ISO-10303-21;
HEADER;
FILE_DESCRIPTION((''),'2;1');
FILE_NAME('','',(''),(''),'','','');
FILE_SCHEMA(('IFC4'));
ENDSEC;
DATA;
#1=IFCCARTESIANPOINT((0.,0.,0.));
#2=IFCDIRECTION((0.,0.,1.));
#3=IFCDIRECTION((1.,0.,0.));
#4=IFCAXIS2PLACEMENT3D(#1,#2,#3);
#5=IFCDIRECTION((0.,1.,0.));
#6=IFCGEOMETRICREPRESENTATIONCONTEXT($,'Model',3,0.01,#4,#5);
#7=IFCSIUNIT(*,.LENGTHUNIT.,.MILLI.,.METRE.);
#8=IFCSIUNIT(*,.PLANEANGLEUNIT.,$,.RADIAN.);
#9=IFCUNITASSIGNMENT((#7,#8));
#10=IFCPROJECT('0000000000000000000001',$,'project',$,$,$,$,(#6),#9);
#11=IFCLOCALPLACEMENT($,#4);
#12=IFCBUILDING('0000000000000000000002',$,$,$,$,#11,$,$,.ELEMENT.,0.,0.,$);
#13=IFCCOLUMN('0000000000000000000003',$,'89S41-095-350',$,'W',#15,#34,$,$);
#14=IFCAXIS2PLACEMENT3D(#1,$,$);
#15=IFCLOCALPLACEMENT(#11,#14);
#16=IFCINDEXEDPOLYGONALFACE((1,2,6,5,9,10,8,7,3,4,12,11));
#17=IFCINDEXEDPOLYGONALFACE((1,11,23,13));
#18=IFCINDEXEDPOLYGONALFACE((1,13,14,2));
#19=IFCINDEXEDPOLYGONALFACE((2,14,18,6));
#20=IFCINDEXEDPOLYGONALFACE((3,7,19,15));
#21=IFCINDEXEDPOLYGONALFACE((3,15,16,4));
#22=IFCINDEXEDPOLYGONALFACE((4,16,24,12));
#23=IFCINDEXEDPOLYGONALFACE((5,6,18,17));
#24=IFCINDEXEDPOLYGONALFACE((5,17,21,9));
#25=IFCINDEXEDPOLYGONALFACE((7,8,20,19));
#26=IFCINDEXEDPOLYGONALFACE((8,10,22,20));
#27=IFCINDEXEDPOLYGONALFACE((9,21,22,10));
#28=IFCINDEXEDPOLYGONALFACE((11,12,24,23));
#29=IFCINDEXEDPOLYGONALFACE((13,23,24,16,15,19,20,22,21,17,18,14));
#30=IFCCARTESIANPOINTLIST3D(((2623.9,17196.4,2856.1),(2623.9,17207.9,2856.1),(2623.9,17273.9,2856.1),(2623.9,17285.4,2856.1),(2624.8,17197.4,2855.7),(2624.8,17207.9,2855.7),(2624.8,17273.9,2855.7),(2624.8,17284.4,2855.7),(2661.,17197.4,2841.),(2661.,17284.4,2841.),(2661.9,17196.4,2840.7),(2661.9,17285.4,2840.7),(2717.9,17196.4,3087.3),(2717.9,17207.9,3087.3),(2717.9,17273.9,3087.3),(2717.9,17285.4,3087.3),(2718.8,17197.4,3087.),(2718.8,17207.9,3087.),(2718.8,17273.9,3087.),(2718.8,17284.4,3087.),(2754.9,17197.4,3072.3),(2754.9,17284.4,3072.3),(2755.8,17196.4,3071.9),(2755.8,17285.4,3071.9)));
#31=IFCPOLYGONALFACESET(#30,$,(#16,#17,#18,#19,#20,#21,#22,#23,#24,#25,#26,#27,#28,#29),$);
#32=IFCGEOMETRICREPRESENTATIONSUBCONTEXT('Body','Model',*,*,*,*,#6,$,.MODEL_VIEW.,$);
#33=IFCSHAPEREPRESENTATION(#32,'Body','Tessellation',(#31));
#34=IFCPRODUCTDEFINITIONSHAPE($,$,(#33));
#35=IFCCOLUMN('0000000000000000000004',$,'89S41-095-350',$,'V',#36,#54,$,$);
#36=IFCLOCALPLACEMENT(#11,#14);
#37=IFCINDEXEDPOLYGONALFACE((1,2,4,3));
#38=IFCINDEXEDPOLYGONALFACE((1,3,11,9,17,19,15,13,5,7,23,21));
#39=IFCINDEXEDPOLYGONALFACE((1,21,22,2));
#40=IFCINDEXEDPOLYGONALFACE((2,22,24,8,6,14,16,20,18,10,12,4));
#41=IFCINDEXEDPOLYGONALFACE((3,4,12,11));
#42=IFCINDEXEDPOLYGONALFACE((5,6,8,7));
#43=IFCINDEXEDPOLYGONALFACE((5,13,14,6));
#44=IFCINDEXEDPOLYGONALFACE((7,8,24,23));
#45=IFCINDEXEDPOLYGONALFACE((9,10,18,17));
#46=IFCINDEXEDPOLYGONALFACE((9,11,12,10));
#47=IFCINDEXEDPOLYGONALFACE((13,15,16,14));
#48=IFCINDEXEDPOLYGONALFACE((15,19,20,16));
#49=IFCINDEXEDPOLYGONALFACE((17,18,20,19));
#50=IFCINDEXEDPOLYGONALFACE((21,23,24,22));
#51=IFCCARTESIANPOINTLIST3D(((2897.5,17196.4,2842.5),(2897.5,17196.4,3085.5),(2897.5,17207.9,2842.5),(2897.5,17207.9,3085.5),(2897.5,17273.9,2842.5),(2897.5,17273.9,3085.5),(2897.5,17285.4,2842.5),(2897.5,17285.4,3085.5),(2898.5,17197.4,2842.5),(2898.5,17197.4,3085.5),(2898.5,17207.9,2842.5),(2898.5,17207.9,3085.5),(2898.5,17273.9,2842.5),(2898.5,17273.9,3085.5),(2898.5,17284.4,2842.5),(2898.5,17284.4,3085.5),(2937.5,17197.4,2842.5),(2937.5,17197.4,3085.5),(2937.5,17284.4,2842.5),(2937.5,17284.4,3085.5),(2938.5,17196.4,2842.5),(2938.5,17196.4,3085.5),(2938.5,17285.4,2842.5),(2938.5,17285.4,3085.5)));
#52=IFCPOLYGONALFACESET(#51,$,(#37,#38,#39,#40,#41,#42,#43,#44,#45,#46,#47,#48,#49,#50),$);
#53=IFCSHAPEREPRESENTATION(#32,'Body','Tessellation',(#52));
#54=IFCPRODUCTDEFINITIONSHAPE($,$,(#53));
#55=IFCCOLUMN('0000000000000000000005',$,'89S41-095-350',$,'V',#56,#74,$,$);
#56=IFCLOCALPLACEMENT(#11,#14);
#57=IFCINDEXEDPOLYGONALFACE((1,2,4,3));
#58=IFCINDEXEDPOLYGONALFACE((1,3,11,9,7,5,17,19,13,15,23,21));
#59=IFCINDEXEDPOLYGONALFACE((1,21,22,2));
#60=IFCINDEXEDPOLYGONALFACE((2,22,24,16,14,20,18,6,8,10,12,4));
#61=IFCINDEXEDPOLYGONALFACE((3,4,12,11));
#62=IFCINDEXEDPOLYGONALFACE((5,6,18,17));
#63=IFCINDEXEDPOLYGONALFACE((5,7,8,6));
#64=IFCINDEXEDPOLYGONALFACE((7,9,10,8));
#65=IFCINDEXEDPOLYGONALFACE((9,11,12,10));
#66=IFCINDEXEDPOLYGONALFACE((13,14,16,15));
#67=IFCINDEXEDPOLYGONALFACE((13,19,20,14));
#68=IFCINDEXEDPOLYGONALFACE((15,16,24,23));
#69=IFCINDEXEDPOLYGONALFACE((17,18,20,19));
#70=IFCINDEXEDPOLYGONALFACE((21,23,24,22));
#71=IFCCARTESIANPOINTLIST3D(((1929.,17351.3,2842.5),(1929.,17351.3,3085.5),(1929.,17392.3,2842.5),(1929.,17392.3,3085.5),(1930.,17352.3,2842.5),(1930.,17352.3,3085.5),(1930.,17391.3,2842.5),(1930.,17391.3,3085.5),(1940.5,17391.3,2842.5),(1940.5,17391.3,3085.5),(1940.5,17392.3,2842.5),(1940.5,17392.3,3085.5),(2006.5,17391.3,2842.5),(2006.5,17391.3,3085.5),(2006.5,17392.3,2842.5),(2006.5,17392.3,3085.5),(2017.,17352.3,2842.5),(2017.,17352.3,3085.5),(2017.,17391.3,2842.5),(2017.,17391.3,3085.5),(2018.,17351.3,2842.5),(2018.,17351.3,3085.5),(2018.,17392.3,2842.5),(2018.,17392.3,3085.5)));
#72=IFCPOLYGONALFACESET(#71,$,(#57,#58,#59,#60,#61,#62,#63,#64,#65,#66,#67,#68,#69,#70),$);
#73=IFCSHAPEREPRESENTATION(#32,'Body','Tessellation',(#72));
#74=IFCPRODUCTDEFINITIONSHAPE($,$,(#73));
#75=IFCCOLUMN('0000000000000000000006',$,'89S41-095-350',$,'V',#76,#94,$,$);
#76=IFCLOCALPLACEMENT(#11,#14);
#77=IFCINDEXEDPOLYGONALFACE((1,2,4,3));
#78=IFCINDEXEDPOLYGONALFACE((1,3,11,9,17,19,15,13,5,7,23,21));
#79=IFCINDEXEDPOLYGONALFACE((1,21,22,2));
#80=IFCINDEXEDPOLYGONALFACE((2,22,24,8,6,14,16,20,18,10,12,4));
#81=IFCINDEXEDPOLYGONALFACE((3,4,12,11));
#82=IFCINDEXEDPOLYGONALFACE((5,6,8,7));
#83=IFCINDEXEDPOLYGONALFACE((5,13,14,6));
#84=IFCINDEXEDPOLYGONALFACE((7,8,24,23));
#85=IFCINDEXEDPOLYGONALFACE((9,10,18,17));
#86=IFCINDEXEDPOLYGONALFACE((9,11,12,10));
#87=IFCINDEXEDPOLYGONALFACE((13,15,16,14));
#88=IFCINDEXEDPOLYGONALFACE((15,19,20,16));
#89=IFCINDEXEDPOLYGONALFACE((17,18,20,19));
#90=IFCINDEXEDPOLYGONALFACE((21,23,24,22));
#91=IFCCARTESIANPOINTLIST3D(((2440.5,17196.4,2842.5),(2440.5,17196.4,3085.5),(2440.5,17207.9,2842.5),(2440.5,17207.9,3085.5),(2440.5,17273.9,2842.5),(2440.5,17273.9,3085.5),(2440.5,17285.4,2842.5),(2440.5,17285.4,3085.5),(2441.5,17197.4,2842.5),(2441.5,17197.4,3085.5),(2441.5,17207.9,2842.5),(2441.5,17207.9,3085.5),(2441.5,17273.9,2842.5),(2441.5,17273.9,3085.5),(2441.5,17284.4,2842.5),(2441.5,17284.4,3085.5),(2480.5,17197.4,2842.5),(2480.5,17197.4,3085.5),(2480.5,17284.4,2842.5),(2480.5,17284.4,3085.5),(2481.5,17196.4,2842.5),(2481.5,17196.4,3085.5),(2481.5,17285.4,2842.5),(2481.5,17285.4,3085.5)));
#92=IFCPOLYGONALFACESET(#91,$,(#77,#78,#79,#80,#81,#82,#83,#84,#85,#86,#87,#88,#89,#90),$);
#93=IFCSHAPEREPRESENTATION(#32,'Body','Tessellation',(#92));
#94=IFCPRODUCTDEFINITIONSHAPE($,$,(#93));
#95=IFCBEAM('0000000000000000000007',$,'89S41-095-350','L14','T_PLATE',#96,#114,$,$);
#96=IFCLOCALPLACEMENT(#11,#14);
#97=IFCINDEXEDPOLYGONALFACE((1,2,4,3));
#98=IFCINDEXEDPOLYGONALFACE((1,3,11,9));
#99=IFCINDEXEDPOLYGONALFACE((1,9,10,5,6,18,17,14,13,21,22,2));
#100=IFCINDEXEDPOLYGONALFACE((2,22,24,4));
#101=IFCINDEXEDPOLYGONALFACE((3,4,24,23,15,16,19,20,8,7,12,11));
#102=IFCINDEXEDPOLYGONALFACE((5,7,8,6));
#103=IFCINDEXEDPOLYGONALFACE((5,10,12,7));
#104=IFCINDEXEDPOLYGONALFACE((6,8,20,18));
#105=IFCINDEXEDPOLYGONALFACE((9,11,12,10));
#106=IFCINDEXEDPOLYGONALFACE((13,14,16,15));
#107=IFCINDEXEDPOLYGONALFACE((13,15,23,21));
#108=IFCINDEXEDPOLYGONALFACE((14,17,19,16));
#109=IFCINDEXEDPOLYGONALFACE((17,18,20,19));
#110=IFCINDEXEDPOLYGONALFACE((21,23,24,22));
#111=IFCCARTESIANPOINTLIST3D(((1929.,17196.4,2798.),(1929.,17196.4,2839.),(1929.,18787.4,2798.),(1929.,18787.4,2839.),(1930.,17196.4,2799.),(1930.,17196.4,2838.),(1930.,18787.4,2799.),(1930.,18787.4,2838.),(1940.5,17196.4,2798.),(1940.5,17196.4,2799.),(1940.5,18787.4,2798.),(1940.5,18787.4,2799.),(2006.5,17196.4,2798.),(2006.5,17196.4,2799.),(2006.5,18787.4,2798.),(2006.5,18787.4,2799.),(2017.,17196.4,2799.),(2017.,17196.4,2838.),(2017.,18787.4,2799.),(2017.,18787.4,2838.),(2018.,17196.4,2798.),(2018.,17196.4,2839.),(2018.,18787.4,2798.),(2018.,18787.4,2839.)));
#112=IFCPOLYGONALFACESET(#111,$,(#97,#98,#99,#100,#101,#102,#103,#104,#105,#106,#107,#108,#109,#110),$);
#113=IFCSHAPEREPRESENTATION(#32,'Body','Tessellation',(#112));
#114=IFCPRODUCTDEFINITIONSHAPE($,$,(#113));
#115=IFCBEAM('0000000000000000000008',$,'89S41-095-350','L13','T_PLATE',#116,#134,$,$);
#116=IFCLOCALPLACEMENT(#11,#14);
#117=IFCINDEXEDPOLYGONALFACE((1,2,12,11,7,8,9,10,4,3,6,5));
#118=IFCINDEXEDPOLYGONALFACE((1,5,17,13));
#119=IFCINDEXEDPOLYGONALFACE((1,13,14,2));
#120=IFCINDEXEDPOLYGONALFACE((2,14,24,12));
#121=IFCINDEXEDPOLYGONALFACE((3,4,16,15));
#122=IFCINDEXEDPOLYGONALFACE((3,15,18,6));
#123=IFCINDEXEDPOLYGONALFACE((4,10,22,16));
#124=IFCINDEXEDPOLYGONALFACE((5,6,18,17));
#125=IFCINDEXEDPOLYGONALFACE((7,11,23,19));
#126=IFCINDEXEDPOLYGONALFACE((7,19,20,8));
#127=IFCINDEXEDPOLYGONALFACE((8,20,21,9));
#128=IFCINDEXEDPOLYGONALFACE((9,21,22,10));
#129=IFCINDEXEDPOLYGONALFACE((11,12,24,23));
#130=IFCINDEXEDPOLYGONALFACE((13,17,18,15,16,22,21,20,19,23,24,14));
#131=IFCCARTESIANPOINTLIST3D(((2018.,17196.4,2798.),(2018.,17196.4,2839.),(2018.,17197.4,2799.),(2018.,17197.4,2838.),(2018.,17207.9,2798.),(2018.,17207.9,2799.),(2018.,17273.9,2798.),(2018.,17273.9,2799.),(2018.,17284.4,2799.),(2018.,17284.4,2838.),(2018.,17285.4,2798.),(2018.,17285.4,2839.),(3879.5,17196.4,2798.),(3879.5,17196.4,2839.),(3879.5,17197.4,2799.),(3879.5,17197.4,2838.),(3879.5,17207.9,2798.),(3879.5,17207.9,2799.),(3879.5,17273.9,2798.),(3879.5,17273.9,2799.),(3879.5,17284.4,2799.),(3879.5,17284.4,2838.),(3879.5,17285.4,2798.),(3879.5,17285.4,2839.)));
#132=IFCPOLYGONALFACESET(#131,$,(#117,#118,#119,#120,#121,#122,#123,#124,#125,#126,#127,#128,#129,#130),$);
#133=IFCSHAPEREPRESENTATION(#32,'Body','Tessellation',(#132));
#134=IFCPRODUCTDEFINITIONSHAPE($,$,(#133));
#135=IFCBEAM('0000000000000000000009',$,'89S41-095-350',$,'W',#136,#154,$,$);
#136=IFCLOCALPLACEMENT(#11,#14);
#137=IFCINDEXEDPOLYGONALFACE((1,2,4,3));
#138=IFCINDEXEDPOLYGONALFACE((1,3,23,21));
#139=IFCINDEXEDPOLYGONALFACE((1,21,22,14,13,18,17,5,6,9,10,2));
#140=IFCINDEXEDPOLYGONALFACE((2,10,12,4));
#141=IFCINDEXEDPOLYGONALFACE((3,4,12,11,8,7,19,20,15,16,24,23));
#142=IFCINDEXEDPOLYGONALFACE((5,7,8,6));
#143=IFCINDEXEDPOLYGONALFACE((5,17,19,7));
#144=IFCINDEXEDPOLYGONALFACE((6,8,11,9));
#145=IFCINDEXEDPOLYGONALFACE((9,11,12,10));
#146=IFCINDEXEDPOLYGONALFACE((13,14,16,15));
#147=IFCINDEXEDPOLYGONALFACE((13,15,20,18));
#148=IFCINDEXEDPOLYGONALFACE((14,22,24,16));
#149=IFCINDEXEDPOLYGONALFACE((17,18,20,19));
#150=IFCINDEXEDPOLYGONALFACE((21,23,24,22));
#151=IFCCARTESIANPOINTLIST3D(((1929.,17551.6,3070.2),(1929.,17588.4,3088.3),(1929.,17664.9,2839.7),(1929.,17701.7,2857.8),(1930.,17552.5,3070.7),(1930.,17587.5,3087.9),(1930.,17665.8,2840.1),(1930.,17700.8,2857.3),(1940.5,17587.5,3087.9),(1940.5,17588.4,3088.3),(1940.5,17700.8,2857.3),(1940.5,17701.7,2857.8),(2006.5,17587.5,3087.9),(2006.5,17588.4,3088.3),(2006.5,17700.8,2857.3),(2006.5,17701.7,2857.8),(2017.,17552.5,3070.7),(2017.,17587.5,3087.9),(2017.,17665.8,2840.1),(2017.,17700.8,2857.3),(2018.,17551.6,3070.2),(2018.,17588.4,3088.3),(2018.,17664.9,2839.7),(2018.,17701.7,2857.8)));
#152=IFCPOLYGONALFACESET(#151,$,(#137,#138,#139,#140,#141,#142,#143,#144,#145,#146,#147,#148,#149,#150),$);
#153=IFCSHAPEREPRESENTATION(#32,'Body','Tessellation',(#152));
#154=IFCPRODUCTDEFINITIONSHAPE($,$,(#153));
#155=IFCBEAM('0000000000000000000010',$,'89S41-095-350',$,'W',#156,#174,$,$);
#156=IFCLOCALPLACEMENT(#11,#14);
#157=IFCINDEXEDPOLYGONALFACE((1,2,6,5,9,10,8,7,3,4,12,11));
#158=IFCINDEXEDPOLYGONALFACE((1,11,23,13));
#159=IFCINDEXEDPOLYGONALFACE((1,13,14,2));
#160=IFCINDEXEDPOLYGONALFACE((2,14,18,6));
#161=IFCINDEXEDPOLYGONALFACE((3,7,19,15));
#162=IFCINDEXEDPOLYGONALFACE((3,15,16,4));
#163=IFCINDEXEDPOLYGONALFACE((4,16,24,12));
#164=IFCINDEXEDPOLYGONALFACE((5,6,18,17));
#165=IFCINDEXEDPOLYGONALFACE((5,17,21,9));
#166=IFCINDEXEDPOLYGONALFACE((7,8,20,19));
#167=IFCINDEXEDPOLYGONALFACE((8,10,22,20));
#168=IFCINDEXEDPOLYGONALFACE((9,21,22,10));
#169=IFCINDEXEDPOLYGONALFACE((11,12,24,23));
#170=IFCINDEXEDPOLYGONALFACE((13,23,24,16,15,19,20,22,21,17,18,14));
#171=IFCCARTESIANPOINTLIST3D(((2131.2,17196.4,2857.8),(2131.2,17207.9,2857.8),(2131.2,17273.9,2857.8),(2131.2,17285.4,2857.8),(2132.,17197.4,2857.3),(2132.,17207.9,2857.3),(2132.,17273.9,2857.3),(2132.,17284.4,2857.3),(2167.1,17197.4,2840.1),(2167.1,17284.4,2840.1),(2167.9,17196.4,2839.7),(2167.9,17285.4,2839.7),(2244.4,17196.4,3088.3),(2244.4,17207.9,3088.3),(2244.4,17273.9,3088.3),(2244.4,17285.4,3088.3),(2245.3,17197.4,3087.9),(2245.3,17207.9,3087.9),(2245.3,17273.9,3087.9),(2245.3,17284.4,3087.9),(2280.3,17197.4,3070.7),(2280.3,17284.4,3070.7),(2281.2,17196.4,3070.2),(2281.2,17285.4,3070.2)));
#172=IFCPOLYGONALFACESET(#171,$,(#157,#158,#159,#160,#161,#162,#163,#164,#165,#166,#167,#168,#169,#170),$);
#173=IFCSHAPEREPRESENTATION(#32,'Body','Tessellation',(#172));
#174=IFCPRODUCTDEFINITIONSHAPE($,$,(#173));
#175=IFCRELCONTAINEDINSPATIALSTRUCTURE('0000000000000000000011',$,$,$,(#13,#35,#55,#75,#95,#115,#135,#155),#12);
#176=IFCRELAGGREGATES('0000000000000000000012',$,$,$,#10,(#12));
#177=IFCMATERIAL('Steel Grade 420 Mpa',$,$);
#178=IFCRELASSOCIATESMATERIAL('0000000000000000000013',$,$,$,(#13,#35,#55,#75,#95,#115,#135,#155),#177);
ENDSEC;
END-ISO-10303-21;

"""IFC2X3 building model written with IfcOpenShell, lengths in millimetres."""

from ifc_helpers import new_model, si_unit, direction, frame, origin, origin_with_axes, origin_2d_with_axis, place, context, subcontext, project, spatial, c_section, extrude, source, transform, mapped, material, element, save


model = new_model("IFC2X3")

# Units and contexts
model_context = context("Model", 3, precision=0.01, world=origin_with_axes(), true_north=direction((0.0, 1.0, 0.0)))
body_context = subcontext(model_context, "Body", "Model", "MODEL_VIEW")
ifc_project = project(units=[si_unit("LENGTHUNIT", "METRE", prefix="MILLI"), si_unit("PLANEANGLEUNIT", "RADIAN")], contexts=[model_context])

# Building
building_placement = place(None, origin_with_axes())
building = spatial("IfcBuilding", under=ifc_project, at=building_placement, CompositionType="ELEMENT", ElevationOfRefHeight=0.0, ElevationOfTerrain=0.0)

# Columns
ifc_material = material(Name="Steel Grade 420 Mpa")
shared_shape_1 = source(origin(), body_context, "Body", "SweptSolid", [
    extrude(c_section(Depth=89.0, Width=41.0, WallThickness=1.0, Girth=11.5, at=origin_2d_with_axis()), origin_with_axes(), (0.0, 0.0, 1.0), 249.6),
])
column_1_placement = place(None, frame((2642.9, 17240.9, 2848.4), z_axis=(0.376416, 0.0, 0.926451), x_axis=(-0.926451, 0.0, 0.376416)))
element("IfcColumn", 1, at=column_1_placement, inside=building, material=ifc_material, Name="89S41-095-350", ObjectType="W", context=body_context, shape_type="MappedRepresentation", body=[
    mapped(shared_shape_1, transform((0.0, 0.0, 0.0), scale=1.0)),
])
shared_shape_2 = source(origin(), body_context, "Body", "SweptSolid", [
    extrude(c_section(Depth=89.0, Width=41.0, WallThickness=1.0, Girth=11.5, at=origin_2d_with_axis()), origin_with_axes(), (0.0, 0.0, 1.0), 243.0),
])
column_2_placement = place(None, frame((2918.0, 17240.9, 2842.5), z_axis=(0.0, 0.0, 1.0), x_axis=(-1.0, 0.0, 0.0)))
element("IfcColumn", 2, at=column_2_placement, inside=building, material=ifc_material, Name="89S41-095-350", ObjectType="V", context=body_context, shape_type="MappedRepresentation", body=[
    mapped(shared_shape_2, transform((0.0, 0.0, 0.0), scale=1.0)),
])
shared_shape_3 = source(origin(), body_context, "Body", "SweptSolid", [
    extrude(c_section(Depth=89.0, Width=41.0, WallThickness=1.0, Girth=11.5, at=origin_2d_with_axis()), origin_with_axes(), (0.0, 0.0, 1.0), 243.0),
])
column_3_placement = place(None, frame((1973.5, 17371.8, 2842.5), z_axis=(0.0, 0.0, 1.0), x_axis=(0.0, 1.0, 0.0)))
element("IfcColumn", 3, at=column_3_placement, inside=building, material=ifc_material, Name="89S41-095-350", ObjectType="V", context=body_context, shape_type="MappedRepresentation", body=[
    mapped(shared_shape_3, transform((0.0, 0.0, 0.0), scale=1.0)),
])
shared_shape_4 = source(origin(), body_context, "Body", "SweptSolid", [
    extrude(c_section(Depth=89.0, Width=41.0, WallThickness=1.0, Girth=11.5, at=origin_2d_with_axis()), origin_with_axes(), (0.0, 0.0, 1.0), 243.0),
])
column_4_placement = place(None, frame((2461.0, 17240.9, 2842.5), z_axis=(0.0, 0.0, 1.0), x_axis=(-1.0, 0.0, 0.0)))
element("IfcColumn", 4, at=column_4_placement, inside=building, material=ifc_material, Name="89S41-095-350", ObjectType="V", context=body_context, shape_type="MappedRepresentation", body=[
    mapped(shared_shape_4, transform((0.0, 0.0, 0.0), scale=1.0)),
])

# Beams
shared_shape_5 = source(origin(), body_context, "Body", "SweptSolid", [
    extrude(c_section(Depth=89.0, Width=41.0, WallThickness=1.0, Girth=11.5, at=origin_2d_with_axis()), origin_with_axes(), (0.0, 0.0, 1.0), 1591.0),
])
beam_1_placement = place(None, frame((1973.5, 18787.4, 2818.5), z_axis=(0.0, -1.0, 0.0), x_axis=(0.0, 0.0, -1.0)))
element("IfcBeam", 5, at=beam_1_placement, inside=building, material=ifc_material, Name="89S41-095-350", Description="L14", ObjectType="T_PLATE", context=body_context, shape_type="MappedRepresentation", body=[
    mapped(shared_shape_5, transform((0.0, 0.0, 0.0), scale=1.0)),
])
shared_shape_6 = source(origin(), body_context, "Body", "SweptSolid", [
    extrude(c_section(Depth=89.0, Width=41.0, WallThickness=1.0, Girth=11.5, at=origin_2d_with_axis()), origin_with_axes(), (0.0, 0.0, 1.0), 1861.5),
])
beam_2_placement = place(None, frame((2018.0, 17240.9, 2818.5), z_axis=(1.0, 0.0, 0.0), x_axis=(0.0, 0.0, -1.0)))
element("IfcBeam", 6, at=beam_2_placement, inside=building, material=ifc_material, Name="89S41-095-350", Description="L13", ObjectType="T_PLATE", context=body_context, shape_type="MappedRepresentation", body=[
    mapped(shared_shape_6, transform((0.0, 0.0, 0.0), scale=1.0)),
])
shared_shape_7 = source(origin(), body_context, "Body", "SweptSolid", [
    extrude(c_section(Depth=89.0, Width=41.0, WallThickness=1.0, Girth=11.5, at=origin_2d_with_axis()), origin_with_axes(), (0.0, 0.0, 1.0), 256.9),
])
beam_3_placement = place(None, frame((1973.5, 17683.3, 2848.7), z_axis=(0.0, -0.44102, 0.897497), x_axis=(0.0, 0.897497, 0.44102)))
element("IfcBeam", 7, at=beam_3_placement, inside=building, material=ifc_material, Name="89S41-095-350", ObjectType="W", context=body_context, shape_type="MappedRepresentation", body=[
    mapped(shared_shape_7, transform((0.0, 0.0, 0.0), scale=1.0)),
])
shared_shape_8 = source(origin(), body_context, "Body", "SweptSolid", [
    extrude(c_section(Depth=89.0, Width=41.0, WallThickness=1.0, Girth=11.5, at=origin_2d_with_axis()), origin_with_axes(), (0.0, 0.0, 1.0), 256.9),
])
beam_4_placement = place(None, frame((2149.6, 17240.9, 2848.7), z_axis=(0.44102, 0.0, 0.897497), x_axis=(-0.897497, 0.0, 0.44102)))
element("IfcBeam", 8, at=beam_4_placement, inside=building, material=ifc_material, Name="89S41-095-350", ObjectType="W", context=body_context, shape_type="MappedRepresentation", body=[
    mapped(shared_shape_8, transform((0.0, 0.0, 0.0), scale=1.0)),
])

save(model, "model.ifc")
